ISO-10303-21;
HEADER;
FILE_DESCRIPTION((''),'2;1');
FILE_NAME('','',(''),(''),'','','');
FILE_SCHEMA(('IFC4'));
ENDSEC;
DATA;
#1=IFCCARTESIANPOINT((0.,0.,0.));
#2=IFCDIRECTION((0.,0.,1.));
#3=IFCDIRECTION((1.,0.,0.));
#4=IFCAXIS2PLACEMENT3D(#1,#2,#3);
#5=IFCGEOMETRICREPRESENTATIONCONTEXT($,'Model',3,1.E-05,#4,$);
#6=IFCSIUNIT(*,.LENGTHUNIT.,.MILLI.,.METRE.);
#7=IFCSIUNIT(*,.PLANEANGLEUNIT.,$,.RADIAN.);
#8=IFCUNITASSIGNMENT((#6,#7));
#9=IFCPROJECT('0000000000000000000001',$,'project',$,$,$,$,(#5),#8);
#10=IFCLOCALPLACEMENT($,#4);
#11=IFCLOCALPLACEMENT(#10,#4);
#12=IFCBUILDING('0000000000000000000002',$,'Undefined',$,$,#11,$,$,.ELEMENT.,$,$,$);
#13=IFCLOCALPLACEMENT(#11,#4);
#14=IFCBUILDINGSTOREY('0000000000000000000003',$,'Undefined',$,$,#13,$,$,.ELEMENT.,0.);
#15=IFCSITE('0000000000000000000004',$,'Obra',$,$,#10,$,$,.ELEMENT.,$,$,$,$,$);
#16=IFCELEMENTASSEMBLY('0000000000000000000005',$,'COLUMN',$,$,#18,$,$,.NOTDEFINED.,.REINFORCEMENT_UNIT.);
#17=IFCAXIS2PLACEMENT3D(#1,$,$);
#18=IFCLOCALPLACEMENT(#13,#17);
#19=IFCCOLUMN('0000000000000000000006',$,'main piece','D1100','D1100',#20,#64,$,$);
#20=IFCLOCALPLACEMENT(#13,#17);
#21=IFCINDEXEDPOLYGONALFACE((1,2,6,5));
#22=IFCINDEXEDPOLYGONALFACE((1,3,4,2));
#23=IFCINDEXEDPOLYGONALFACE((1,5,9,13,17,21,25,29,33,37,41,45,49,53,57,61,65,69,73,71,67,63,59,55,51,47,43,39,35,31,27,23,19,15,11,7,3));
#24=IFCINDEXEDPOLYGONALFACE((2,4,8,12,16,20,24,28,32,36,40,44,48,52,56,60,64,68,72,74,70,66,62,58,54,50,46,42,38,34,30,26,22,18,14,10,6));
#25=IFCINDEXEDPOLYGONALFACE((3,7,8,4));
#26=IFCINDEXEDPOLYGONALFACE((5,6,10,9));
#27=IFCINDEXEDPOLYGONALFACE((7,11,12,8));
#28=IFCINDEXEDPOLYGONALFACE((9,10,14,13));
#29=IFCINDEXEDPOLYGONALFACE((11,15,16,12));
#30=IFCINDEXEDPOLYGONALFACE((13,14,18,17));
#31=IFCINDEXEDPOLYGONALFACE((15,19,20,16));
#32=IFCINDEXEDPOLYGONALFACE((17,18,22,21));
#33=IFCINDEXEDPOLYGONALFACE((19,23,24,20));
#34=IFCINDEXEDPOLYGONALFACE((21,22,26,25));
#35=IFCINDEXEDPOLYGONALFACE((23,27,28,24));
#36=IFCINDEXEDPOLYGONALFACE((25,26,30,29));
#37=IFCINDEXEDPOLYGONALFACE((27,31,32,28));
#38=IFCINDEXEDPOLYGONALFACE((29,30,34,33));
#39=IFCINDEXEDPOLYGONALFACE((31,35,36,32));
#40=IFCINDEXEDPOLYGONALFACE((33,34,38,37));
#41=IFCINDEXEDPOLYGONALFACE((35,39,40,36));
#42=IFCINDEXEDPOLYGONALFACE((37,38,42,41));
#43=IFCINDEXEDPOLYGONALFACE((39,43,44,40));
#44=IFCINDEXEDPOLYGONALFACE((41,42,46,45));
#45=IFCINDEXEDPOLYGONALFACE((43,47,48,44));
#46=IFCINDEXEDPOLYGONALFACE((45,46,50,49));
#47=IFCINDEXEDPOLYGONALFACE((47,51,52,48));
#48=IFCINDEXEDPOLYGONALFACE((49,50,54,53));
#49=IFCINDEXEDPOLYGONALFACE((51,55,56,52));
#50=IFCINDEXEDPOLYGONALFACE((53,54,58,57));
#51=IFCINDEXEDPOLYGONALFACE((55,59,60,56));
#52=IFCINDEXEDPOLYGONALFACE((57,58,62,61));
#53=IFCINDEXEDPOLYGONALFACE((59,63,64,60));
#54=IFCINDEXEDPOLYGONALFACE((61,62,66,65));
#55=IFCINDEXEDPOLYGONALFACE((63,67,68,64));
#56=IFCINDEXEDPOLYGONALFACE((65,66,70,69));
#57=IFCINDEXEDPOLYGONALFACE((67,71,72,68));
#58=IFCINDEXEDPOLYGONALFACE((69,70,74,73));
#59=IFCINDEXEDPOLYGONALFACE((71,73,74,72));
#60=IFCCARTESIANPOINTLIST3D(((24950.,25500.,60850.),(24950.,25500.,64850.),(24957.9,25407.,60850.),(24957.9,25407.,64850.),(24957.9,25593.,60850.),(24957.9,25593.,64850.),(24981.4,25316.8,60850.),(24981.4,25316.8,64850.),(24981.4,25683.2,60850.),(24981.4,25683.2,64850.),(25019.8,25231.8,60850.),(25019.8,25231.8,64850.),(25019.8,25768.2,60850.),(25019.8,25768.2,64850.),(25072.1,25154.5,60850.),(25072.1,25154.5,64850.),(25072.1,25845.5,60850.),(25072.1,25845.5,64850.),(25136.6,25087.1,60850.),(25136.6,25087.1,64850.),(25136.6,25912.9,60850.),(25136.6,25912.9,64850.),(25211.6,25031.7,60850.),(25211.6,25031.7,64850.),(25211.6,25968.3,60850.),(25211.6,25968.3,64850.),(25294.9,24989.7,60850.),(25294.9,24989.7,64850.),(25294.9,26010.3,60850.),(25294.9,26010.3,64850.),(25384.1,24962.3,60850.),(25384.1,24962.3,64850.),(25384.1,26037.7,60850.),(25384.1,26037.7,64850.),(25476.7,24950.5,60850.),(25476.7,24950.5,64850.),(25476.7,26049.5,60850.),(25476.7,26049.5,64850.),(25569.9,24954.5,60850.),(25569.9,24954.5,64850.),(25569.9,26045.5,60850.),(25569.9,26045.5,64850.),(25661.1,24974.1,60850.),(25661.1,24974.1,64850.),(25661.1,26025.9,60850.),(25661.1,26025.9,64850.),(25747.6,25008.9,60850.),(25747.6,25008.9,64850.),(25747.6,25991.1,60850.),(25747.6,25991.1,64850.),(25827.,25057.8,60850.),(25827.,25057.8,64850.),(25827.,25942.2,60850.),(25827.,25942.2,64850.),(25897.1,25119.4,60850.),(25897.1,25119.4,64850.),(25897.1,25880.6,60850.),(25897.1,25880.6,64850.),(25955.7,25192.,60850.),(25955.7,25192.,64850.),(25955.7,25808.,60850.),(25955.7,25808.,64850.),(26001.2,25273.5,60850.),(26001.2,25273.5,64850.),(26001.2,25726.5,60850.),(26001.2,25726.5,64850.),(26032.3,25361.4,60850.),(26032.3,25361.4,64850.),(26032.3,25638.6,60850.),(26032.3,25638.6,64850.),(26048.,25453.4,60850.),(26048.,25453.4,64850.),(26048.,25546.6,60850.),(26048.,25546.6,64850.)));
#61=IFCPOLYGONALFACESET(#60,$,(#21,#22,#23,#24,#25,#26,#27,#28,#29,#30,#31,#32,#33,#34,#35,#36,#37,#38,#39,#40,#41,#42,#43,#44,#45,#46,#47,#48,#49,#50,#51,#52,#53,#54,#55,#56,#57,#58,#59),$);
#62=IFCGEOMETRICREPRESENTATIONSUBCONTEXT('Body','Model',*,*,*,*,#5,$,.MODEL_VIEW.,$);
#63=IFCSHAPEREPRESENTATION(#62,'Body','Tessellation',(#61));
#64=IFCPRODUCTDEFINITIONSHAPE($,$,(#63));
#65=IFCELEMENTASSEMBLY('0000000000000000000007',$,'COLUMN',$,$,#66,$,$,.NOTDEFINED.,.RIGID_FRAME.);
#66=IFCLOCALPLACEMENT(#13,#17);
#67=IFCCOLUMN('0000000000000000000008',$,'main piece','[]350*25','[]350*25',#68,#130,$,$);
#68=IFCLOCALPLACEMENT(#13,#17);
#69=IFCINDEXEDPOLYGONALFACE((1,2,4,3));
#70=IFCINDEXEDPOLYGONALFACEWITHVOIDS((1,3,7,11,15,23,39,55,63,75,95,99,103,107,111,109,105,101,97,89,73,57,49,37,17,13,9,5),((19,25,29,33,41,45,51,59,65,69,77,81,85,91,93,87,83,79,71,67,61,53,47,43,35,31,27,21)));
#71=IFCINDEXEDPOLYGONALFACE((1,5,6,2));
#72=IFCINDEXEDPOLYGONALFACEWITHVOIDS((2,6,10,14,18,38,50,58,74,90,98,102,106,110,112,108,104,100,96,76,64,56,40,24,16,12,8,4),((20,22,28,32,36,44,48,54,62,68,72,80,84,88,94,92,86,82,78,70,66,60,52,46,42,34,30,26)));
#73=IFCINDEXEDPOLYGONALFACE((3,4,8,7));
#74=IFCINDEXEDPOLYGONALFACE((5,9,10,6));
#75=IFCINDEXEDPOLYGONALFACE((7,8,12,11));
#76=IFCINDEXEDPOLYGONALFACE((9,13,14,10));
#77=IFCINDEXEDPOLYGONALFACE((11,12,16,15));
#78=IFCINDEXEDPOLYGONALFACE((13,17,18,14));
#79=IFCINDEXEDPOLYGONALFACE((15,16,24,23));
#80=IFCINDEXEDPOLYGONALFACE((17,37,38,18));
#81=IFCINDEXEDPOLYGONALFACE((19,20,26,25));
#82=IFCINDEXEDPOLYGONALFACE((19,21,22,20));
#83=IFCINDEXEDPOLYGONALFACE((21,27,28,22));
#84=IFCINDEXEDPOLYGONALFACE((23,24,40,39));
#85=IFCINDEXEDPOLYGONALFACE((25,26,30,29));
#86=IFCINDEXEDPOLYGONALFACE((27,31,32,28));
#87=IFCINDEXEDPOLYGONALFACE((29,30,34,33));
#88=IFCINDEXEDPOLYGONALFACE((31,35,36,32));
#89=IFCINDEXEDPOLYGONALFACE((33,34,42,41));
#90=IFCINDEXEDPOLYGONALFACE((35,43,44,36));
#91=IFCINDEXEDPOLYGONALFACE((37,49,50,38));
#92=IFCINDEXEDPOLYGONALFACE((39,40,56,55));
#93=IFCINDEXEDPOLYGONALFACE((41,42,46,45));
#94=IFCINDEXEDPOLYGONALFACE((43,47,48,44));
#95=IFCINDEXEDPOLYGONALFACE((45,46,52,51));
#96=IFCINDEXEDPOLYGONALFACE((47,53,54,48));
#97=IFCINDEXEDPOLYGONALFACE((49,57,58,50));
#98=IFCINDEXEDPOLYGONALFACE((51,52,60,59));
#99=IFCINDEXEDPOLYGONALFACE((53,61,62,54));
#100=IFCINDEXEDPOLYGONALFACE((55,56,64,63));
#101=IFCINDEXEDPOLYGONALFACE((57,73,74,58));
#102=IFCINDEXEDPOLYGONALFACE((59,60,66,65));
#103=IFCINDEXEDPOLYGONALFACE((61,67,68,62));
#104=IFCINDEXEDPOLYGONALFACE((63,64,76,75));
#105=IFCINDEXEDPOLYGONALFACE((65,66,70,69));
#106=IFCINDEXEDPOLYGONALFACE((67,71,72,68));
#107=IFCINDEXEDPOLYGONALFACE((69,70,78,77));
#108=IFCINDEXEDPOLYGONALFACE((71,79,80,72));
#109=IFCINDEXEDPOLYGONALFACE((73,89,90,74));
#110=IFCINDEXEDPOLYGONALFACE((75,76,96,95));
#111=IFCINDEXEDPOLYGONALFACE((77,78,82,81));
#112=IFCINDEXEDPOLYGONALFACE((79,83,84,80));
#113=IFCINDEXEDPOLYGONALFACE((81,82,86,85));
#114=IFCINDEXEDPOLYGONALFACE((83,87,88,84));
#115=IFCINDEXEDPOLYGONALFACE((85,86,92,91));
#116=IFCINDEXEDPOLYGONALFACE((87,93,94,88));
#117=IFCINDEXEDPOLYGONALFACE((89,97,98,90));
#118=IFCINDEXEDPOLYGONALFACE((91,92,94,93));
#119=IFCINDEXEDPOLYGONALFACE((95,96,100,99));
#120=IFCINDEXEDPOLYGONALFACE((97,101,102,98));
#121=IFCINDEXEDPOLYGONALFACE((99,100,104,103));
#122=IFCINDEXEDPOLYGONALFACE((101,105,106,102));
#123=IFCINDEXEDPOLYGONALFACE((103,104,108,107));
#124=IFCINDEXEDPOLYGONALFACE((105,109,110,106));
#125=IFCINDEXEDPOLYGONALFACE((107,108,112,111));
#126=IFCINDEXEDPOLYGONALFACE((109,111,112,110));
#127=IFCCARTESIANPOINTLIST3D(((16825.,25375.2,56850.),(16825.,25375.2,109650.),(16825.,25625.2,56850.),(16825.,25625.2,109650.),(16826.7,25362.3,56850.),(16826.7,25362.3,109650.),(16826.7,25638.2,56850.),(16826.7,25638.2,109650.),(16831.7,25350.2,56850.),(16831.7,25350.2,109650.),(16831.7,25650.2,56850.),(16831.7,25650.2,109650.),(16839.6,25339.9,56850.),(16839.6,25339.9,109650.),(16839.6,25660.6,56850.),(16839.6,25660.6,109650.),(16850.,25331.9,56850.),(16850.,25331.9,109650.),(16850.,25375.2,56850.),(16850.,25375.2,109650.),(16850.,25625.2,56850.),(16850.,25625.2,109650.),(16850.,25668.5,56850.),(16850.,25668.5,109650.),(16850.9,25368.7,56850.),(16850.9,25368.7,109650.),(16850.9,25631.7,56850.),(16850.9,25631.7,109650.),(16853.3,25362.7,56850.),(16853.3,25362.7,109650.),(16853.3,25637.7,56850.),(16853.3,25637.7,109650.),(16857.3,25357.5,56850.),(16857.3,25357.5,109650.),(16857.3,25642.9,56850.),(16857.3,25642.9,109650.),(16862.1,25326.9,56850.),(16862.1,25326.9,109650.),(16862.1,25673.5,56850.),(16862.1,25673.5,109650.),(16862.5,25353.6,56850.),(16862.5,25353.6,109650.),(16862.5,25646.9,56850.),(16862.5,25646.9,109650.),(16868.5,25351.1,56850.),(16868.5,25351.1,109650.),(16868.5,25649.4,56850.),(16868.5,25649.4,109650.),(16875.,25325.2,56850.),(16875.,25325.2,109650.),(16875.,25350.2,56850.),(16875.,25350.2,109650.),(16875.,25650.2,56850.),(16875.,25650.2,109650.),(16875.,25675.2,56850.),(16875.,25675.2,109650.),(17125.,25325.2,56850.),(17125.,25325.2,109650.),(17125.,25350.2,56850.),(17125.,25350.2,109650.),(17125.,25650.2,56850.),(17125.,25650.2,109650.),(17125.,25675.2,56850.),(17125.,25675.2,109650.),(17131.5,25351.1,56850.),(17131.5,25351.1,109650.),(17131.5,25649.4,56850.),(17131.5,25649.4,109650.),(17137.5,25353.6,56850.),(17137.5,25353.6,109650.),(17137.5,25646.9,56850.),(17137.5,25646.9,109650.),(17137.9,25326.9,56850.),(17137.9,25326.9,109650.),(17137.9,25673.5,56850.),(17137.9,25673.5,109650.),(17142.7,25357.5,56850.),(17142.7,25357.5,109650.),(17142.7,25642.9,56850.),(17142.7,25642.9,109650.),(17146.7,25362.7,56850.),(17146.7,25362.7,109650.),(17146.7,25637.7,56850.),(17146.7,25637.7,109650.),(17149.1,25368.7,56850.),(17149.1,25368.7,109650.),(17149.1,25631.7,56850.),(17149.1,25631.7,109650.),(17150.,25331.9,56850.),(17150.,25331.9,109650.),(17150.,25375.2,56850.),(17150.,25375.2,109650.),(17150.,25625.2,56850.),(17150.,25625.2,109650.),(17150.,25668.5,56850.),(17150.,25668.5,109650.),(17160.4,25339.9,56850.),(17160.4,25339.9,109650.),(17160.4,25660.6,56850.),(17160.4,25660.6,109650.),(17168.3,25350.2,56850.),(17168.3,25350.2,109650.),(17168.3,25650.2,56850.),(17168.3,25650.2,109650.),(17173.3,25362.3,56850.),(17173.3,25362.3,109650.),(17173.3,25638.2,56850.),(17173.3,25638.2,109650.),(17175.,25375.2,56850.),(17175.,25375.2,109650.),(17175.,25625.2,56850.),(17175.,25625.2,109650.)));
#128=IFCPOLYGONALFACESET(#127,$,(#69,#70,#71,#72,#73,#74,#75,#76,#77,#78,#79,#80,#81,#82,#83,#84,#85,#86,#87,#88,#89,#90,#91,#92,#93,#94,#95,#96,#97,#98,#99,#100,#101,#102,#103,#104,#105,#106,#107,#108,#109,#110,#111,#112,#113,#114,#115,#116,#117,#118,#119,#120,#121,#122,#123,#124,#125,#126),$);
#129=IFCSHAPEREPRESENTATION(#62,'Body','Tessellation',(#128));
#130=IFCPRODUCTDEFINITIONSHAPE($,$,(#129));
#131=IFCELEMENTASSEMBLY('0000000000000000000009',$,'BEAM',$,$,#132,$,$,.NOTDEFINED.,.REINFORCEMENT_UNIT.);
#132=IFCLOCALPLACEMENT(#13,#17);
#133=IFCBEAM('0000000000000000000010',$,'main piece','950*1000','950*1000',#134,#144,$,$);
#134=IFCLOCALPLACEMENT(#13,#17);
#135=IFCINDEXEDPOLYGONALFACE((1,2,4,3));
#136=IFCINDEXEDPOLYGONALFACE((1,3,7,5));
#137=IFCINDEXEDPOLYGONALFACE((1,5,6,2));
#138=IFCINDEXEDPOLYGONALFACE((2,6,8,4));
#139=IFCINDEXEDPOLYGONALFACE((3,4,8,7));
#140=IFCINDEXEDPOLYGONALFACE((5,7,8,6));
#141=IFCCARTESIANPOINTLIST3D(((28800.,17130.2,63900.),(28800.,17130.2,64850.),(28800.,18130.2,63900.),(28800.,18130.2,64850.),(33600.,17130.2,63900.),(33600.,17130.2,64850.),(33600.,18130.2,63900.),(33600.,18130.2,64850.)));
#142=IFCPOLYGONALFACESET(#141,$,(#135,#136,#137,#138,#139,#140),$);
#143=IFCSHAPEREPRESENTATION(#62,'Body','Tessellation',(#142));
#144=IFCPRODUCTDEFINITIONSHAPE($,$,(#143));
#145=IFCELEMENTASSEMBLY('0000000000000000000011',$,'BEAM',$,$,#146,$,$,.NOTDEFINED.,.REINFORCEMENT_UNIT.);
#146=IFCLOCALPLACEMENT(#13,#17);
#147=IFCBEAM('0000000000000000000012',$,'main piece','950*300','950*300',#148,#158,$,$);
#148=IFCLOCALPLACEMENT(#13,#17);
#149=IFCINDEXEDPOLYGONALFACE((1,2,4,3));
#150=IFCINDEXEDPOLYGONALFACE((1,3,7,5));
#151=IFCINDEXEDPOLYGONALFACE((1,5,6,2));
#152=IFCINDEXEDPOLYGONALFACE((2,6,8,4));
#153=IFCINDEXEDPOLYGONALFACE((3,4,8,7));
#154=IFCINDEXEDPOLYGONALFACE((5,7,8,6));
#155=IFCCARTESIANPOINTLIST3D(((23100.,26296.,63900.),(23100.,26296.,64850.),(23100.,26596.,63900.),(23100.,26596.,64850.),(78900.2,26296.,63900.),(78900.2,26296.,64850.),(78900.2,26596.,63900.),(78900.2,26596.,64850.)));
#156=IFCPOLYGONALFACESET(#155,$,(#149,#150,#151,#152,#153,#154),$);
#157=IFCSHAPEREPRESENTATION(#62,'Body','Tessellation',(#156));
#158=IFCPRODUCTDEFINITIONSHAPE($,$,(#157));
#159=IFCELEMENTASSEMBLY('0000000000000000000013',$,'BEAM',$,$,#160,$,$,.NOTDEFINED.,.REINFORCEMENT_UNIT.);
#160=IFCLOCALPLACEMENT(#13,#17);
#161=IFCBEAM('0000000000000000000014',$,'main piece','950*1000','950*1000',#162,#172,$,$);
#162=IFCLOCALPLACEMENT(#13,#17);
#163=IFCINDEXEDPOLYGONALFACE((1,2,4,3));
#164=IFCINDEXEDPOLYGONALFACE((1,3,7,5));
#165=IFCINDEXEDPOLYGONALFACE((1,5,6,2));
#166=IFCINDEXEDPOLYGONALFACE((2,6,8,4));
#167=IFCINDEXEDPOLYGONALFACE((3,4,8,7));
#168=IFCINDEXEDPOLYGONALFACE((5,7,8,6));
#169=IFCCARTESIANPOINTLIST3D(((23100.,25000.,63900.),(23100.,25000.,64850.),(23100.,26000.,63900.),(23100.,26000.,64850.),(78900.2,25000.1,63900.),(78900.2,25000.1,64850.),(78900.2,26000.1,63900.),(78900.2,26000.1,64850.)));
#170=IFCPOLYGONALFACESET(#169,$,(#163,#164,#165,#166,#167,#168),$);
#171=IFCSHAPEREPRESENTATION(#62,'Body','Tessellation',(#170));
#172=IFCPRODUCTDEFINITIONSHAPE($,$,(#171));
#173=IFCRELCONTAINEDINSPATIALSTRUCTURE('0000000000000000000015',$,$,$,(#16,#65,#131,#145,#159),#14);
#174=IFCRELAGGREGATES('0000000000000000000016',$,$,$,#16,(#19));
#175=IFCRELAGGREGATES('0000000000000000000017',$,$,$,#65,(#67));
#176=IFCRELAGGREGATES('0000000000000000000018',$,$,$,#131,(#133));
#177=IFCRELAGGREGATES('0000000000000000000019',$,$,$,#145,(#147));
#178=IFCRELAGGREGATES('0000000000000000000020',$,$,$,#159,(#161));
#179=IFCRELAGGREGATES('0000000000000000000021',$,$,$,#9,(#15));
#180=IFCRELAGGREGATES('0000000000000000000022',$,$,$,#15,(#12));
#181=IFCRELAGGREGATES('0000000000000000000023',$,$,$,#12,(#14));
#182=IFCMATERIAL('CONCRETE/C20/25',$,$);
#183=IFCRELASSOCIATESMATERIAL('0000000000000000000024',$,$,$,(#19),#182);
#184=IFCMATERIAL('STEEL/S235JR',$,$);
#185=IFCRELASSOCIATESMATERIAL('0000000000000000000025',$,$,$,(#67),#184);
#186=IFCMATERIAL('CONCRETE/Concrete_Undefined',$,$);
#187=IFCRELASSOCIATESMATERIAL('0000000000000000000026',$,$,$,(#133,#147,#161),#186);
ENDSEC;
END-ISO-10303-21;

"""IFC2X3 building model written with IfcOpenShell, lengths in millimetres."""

from ifc_helpers import new_model, si_unit, frame, origin_with_axes, origin_2d_with_axis, place, context, subcontext, project, spatial, rectangle, hollow_rectangle, circle, extrude, material, element, aggregate, save


model = new_model("IFC2X3")

# Units and contexts
model_context = context("Model", 3, precision=1e-05, world=origin_with_axes())
body_context = subcontext(model_context, "Body", "Model", "MODEL_VIEW")
ifc_project = project(units=[si_unit("LENGTHUNIT", "METRE", prefix="MILLI"), si_unit("PLANEANGLEUNIT", "RADIAN")], contexts=[model_context])

# Site, building, storey
site_placement = place(None, origin_with_axes())
site = spatial("IfcSite", under=ifc_project, at=site_placement, Name="Obra", CompositionType="ELEMENT")
building_placement = place(site_placement, origin_with_axes())
building = spatial("IfcBuilding", under=site, at=building_placement, Name="Undefined", CompositionType="ELEMENT")
storey_placement = place(building_placement, origin_with_axes())
storey = spatial("IfcBuildingStorey", under=building, at=storey_placement, Name="Undefined", CompositionType="ELEMENT", Elevation=0.0)

# Element assemblies, columns
assembly_1_placement = place(storey_placement, origin_with_axes())
assembly_1 = element("IfcElementAssembly", 1, at=assembly_1_placement, inside=storey, Name="COLUMN", AssemblyPlace="NOTDEFINED", PredefinedType="REINFORCEMENT_UNIT")
ifc_material_1 = material(Name="CONCRETE/C20/25")
column_1_placement = place(assembly_1_placement, frame((25500.0, 25500.0, 60850.0), z_axis=(0.0, 0.0, 1.0), x_axis=(0.0, 1.0, 0.0)))
column_1 = element("IfcColumn", 2, at=column_1_placement, material=ifc_material_1, Name="main piece", Description="D1100", ObjectType="D1100", context=body_context, shape_type="SweptSolid", body=[
    extrude(circle(Radius=550.0, at=origin_2d_with_axis()), frame((0.0, 0.0, 4000.0), z_axis=(0.0, 0.0, -1.0), x_axis=(0.0, 1.0, 0.0)), (0.0, 0.0, 1.0), 4000.0),
])
aggregate(assembly_1, [column_1])
assembly_2_placement = place(storey_placement, origin_with_axes())
assembly_2 = element("IfcElementAssembly", 3, at=assembly_2_placement, inside=storey, Name="COLUMN", AssemblyPlace="NOTDEFINED", PredefinedType="RIGID_FRAME")
ifc_material_2 = material(Name="STEEL/S235JR")
column_2_placement = place(assembly_2_placement, frame((17000.0, 25500.2, 56850.0), z_axis=(0.0, 0.0, 1.0), x_axis=(0.0, 1.0, 0.0)))
column_2 = element("IfcColumn", 4, at=column_2_placement, material=ifc_material_2, Name="main piece", Description="[]350*25", ObjectType="[]350*25", context=body_context, shape_type="SweptSolid", body=[
    extrude(hollow_rectangle(XDim=350.0, YDim=350.0, WallThickness=25.0, InnerFilletRadius=25.0, OuterFilletRadius=50.0, at=origin_2d_with_axis()), frame((0.0, 0.0, 52800.0), z_axis=(0.0, 0.0, -1.0), x_axis=(0.0, 1.0, 0.0)), (0.0, 0.0, 1.0), 52800.0),
])
aggregate(assembly_2, [column_2])

# Element assemblies, beams
assembly_3_placement = place(storey_placement, origin_with_axes())
assembly_3 = element("IfcElementAssembly", 5, at=assembly_3_placement, inside=storey, Name="BEAM", AssemblyPlace="NOTDEFINED", PredefinedType="REINFORCEMENT_UNIT")
ifc_material_3 = material(Name="CONCRETE/Concrete_Undefined")
beam_1_placement = place(assembly_3_placement, frame((28800.0, 17630.2, 64375.0), z_axis=(0.0, 0.0, 1.0), x_axis=(1.0, 0.000002, 0.0)))
beam_1 = element("IfcBeam", 6, at=beam_1_placement, material=ifc_material_3, Name="main piece", Description="950*1000", ObjectType="950*1000", context=body_context, shape_type="SweptSolid", body=[
    extrude(rectangle(XDim=1000.0, YDim=950.0, at=origin_2d_with_axis()), frame((4800.0, 0.0, 0.0), z_axis=(-1.0, 0.0, 0.0), x_axis=(0.0, -1.0, 0.0)), (0.0, 0.0, 1.0), 4800.0),
])
aggregate(assembly_3, [beam_1])
assembly_4_placement = place(storey_placement, origin_with_axes())
assembly_4 = element("IfcElementAssembly", 7, at=assembly_4_placement, inside=storey, Name="BEAM", AssemblyPlace="NOTDEFINED", PredefinedType="REINFORCEMENT_UNIT")
beam_2_placement = place(assembly_4_placement, frame((23100.0, 26446.0, 64375.0), z_axis=(0.0, 0.0, 1.0), x_axis=(1.0, 0.0, 0.0)))
beam_2 = element("IfcBeam", 8, at=beam_2_placement, material=ifc_material_3, Name="main piece", Description="950*300", ObjectType="950*300", context=body_context, shape_type="SweptSolid", body=[
    extrude(rectangle(XDim=300.0, YDim=950.0, at=origin_2d_with_axis()), frame((55800.2, 0.0, 0.0), z_axis=(-1.0, 0.0, 0.0), x_axis=(0.0, -1.0, 0.0)), (0.0, 0.0, 1.0), 55800.2),
])
aggregate(assembly_4, [beam_2])
assembly_5_placement = place(storey_placement, origin_with_axes())
assembly_5 = element("IfcElementAssembly", 9, at=assembly_5_placement, inside=storey, Name="BEAM", AssemblyPlace="NOTDEFINED", PredefinedType="REINFORCEMENT_UNIT")
beam_3_placement = place(assembly_5_placement, frame((23100.0, 25500.0, 64375.0), z_axis=(0.0, 0.0, 1.0), x_axis=(1.0, 0.000002, 0.0)))
beam_3 = element("IfcBeam", 10, at=beam_3_placement, material=ifc_material_3, Name="main piece", Description="950*1000", ObjectType="950*1000", context=body_context, shape_type="SweptSolid", body=[
    extrude(rectangle(XDim=1000.0, YDim=950.0, at=origin_2d_with_axis()), frame((55800.2, 0.0, 0.0), z_axis=(-1.0, 0.0, 0.0), x_axis=(0.0, -1.0, 0.0)), (0.0, 0.0, 1.0), 55800.2),
])
aggregate(assembly_5, [beam_3])

save(model, "model.ifc")
